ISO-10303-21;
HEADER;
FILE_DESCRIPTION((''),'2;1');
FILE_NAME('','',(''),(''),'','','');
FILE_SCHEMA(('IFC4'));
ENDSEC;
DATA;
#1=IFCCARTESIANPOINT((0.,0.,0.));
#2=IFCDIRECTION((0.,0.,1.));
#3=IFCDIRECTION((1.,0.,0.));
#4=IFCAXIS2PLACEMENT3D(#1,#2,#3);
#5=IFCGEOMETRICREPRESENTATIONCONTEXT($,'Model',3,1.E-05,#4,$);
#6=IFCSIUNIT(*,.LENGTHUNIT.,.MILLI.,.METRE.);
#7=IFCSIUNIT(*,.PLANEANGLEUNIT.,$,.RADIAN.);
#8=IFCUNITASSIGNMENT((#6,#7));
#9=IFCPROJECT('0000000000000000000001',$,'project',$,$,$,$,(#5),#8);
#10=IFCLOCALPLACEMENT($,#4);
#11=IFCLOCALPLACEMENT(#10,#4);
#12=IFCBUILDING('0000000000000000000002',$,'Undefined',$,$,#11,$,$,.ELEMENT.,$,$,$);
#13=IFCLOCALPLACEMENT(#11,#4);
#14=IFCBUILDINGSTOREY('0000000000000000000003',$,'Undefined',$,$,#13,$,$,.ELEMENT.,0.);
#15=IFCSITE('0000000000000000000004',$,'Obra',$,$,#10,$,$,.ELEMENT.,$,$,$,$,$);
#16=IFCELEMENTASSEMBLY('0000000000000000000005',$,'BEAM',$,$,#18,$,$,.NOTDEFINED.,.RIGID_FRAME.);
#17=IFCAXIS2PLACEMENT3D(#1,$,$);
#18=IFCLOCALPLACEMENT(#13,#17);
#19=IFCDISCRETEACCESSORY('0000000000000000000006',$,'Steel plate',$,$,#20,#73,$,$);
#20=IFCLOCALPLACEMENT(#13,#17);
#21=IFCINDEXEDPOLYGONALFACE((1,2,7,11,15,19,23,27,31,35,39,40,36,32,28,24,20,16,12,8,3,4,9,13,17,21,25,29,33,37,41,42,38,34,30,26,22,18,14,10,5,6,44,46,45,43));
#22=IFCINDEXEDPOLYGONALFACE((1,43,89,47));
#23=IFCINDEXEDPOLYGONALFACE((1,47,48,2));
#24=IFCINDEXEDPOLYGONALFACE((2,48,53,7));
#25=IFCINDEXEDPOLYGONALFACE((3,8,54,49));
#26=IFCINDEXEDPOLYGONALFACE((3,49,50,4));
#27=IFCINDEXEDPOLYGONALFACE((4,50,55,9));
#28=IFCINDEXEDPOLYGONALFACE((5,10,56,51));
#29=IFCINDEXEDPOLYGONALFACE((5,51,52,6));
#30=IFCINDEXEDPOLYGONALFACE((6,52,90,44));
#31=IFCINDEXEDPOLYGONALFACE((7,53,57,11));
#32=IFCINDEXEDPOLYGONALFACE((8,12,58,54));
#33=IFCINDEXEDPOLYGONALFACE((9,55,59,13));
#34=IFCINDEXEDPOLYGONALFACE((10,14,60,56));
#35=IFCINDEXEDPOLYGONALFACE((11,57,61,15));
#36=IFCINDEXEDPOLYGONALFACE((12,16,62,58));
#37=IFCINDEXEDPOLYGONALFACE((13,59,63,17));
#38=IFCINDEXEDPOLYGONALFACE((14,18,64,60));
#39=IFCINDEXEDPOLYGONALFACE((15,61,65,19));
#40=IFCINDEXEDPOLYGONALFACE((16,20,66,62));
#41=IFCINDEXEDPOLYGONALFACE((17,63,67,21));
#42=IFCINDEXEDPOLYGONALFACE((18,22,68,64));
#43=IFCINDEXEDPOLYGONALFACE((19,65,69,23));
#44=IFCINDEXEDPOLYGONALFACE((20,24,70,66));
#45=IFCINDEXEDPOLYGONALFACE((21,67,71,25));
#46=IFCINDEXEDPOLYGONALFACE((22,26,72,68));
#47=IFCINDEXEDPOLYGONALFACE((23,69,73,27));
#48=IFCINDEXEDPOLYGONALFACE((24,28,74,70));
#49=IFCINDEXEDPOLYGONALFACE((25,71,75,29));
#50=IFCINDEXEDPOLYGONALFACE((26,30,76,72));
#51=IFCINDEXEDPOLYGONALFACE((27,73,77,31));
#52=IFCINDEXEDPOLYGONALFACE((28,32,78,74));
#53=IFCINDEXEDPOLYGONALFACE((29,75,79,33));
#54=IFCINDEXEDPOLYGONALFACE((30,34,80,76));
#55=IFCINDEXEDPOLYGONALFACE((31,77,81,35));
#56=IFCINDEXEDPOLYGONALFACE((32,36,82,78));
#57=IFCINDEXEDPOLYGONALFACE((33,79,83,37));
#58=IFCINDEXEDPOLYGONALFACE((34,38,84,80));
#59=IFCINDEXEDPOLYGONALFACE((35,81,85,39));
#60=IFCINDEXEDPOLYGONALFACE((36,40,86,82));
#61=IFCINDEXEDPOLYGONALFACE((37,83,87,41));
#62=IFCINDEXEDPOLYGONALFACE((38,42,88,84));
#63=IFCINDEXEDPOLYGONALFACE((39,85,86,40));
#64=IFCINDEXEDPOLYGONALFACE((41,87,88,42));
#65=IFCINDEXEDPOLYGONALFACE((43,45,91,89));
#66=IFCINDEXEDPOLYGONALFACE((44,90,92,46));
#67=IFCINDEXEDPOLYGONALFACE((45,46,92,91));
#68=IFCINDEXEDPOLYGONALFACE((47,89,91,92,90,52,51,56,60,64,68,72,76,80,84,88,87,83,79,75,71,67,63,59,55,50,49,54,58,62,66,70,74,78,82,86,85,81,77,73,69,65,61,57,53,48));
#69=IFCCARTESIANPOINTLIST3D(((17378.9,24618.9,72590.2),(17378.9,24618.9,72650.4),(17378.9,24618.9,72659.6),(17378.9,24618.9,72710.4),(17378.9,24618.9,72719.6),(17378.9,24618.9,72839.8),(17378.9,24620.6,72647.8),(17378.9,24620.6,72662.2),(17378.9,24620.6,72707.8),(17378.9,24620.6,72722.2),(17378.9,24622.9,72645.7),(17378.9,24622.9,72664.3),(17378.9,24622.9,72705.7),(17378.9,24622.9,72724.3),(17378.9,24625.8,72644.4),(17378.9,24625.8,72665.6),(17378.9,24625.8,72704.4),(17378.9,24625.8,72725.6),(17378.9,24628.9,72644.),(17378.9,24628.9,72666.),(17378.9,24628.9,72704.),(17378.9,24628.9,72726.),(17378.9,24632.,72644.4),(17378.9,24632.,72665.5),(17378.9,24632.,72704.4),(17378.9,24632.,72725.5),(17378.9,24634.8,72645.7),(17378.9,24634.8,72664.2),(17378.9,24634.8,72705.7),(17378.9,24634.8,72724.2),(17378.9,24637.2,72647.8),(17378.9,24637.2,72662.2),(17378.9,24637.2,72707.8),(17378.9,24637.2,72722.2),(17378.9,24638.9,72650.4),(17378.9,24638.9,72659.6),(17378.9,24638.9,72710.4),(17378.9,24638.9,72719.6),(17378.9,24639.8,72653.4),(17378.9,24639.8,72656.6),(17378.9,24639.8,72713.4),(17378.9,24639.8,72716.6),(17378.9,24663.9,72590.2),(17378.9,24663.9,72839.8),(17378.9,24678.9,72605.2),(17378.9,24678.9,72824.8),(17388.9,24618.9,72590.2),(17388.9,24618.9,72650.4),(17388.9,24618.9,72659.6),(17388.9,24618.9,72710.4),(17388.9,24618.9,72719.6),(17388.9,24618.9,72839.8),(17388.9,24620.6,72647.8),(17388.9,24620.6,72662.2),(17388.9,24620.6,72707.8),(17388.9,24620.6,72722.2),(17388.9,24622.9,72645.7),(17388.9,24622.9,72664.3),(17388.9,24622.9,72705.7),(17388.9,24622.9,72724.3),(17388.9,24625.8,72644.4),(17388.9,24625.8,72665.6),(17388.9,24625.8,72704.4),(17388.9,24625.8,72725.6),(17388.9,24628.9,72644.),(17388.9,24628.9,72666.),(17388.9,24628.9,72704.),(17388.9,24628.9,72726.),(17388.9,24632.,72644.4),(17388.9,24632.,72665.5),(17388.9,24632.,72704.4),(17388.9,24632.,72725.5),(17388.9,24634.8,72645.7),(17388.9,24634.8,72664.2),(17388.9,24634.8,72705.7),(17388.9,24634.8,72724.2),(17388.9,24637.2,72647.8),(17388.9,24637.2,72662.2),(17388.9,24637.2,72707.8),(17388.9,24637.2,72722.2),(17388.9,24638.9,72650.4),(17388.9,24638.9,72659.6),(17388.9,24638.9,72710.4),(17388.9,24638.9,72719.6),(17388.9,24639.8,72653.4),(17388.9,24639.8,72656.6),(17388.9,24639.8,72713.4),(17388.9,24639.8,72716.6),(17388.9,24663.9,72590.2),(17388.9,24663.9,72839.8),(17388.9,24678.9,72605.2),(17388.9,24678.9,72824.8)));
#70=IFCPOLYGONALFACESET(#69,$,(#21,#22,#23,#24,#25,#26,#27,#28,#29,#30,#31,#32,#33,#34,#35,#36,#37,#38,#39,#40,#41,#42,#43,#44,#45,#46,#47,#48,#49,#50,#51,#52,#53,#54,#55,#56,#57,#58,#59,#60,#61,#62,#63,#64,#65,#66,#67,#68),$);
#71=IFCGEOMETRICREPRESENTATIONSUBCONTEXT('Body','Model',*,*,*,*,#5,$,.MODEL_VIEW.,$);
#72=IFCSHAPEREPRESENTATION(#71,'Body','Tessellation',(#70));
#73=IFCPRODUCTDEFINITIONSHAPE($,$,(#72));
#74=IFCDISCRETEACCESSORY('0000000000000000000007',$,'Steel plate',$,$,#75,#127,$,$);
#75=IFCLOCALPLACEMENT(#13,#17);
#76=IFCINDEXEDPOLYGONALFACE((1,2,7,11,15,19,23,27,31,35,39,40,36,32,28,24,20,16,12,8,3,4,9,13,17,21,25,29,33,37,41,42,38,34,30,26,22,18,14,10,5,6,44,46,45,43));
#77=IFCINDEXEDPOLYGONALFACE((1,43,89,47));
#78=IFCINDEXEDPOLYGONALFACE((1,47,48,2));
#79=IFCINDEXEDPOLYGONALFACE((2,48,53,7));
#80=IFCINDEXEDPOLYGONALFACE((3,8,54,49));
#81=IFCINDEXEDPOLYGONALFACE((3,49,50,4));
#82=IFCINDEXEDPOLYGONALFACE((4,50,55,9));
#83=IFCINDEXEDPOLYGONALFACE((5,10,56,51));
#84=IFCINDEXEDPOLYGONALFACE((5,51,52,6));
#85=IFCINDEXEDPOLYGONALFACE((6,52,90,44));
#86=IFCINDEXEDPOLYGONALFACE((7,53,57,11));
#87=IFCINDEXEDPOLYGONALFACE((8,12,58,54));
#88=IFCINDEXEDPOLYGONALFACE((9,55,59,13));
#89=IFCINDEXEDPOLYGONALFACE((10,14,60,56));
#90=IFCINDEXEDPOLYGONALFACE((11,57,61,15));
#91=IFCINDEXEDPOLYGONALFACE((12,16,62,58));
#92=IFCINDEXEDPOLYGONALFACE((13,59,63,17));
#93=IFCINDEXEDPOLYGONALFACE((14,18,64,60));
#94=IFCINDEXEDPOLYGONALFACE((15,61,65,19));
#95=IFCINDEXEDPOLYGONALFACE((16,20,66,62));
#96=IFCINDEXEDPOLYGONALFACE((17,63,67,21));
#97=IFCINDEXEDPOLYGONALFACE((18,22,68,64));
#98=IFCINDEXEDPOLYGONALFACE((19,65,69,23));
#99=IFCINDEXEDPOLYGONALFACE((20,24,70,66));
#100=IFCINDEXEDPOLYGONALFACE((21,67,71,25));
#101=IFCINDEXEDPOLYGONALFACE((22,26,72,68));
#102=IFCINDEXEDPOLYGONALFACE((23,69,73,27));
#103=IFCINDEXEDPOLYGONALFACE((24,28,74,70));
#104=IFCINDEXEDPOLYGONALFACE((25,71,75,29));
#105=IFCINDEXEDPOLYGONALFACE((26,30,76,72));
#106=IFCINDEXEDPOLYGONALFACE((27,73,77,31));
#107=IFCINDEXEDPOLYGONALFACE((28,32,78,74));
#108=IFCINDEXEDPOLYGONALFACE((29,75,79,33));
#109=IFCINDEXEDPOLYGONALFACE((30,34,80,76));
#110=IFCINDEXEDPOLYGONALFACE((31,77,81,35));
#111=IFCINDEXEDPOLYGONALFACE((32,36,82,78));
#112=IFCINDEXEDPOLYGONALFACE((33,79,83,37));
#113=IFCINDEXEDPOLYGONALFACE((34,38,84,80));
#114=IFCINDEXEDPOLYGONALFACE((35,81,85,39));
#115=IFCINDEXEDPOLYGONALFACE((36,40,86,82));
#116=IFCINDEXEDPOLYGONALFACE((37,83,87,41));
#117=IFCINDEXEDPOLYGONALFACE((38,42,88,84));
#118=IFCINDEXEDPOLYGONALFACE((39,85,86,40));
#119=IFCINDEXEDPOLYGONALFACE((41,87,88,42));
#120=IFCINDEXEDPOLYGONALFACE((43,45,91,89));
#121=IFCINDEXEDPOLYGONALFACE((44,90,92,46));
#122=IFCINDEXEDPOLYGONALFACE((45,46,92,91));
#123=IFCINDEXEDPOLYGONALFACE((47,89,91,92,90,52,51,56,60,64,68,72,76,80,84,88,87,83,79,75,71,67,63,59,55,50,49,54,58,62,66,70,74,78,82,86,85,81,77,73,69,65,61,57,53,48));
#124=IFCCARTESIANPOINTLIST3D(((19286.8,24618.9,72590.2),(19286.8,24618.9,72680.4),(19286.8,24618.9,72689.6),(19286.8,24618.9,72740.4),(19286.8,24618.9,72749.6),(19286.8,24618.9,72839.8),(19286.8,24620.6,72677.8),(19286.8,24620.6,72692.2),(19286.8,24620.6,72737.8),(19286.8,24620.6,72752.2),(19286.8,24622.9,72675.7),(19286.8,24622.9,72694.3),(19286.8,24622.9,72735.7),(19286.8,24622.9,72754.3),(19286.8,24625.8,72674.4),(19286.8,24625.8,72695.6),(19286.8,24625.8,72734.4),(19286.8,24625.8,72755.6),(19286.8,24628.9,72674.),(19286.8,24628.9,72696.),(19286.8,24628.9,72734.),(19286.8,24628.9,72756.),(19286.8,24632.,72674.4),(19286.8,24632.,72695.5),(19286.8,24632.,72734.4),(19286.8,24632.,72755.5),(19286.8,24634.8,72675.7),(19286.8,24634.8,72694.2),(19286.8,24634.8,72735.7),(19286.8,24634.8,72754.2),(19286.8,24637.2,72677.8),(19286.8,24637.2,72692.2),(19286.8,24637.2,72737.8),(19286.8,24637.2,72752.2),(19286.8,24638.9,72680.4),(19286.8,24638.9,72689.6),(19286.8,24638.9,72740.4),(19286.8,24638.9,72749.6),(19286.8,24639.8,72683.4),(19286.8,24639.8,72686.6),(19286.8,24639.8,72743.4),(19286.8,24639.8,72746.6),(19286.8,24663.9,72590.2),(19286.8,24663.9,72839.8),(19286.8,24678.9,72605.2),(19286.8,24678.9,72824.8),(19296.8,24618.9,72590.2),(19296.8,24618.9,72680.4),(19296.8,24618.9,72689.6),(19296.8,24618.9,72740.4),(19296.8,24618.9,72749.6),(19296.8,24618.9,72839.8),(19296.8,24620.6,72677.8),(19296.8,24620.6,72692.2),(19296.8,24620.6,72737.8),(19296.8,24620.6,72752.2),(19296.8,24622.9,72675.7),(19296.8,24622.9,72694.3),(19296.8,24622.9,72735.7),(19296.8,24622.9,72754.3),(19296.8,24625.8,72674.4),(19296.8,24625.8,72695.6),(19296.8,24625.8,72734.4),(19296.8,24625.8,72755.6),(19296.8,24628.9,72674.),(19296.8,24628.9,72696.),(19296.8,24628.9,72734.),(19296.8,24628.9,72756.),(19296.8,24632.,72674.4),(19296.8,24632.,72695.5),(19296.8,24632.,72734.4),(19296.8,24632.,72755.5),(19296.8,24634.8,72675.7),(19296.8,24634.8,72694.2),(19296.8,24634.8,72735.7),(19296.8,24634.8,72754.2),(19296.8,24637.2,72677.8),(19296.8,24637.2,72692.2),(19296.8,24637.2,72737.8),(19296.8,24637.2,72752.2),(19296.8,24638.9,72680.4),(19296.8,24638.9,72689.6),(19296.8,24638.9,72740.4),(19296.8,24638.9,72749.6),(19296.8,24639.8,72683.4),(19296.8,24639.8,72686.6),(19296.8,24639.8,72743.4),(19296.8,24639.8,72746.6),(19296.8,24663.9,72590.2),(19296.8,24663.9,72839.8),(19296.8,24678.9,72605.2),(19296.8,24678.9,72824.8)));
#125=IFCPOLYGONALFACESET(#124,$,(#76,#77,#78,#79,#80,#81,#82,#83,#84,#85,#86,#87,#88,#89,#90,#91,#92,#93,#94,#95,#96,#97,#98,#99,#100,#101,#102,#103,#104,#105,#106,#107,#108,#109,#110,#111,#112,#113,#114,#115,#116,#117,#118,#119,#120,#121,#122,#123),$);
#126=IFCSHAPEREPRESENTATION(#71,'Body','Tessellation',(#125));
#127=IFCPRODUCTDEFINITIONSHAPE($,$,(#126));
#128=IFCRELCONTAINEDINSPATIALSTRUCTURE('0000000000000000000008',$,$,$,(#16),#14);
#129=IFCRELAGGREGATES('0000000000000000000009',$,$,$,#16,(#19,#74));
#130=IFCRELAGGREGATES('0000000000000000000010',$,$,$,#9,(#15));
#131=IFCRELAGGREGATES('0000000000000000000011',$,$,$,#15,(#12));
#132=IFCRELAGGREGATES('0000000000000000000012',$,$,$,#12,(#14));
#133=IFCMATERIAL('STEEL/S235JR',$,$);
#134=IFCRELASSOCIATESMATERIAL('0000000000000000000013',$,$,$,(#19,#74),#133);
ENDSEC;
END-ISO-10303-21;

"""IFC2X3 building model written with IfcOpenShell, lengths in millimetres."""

from ifc_helpers import new_model, si_unit, frame, origin_with_axes, origin_2d_with_axis, place, context, subcontext, project, spatial, polyline, circle, outline, extrude, source, transform, mapped, material, element, aggregate, save


model = new_model("IFC2X3")

# Units and contexts
model_context = context("Model", 3, precision=1e-05, world=origin_with_axes())
body_context = subcontext(model_context, "Body", "Model", "MODEL_VIEW")
ifc_project = project(units=[si_unit("LENGTHUNIT", "METRE", prefix="MILLI"), si_unit("PLANEANGLEUNIT", "RADIAN")], contexts=[model_context])

# Site, building, storey
site_placement = place(None, origin_with_axes())
site = spatial("IfcSite", under=ifc_project, at=site_placement, Name="Obra", CompositionType="ELEMENT")
building_placement = place(site_placement, origin_with_axes())
building = spatial("IfcBuilding", under=site, at=building_placement, Name="Undefined", CompositionType="ELEMENT")
storey_placement = place(building_placement, origin_with_axes())
storey = spatial("IfcBuildingStorey", under=building, at=storey_placement, Name="Undefined", CompositionType="ELEMENT", Elevation=0.0)

# Shared definitions
ifc_material_1 = material(Name="STEEL/S235JR")

# Element assembly
assembly_1_placement = place(storey_placement, origin_with_axes())
assembly_1 = element("IfcElementAssembly", 1, at=assembly_1_placement, inside=storey, Name="BEAM", AssemblyPlace="NOTDEFINED", PredefinedType="RIGID_FRAME")

# Discrete accessories, openings
discrete_accessory_1_placement = place(assembly_1_placement, frame((17383.9, 24618.9, 72590.2), z_axis=(1.0, 0.000002, 0.0), x_axis=(-0.000002, 1.0, 0.0)))
discrete_accessory_1 = element("IfcDiscreteAccessory", 2, at=discrete_accessory_1_placement, material=ifc_material_1, Name="Steel plate", context=body_context, shape_type="SweptSolid", body=[
    extrude(outline(polyline([(0.0, 0.0), (45.0, 0.0), (60.0, 15.0), (60.0, 234.6), (45.0, 249.6), (0.0, 249.6), (0.0, 0.0)])), frame((0.0, 0.0, -5.0), z_axis=(0.0, 0.0, 1.0), x_axis=(1.0, 0.0, 0.0)), (0.0, 0.0, 1.0), 10.0),
])
shared_shape_1 = source(origin_with_axes(), body_context, "Body", "SweptSolid", [
    extrude(circle(Radius=11.0, at=origin_2d_with_axis()), frame((0.0, -13.9, 0.0), z_axis=(0.0, 1.0, 0.0), x_axis=(1.0, 0.0, 0.0)), (0.0, 0.0, 1.0), 10.2),
])
opening_1_placement = place(assembly_1_placement, frame((17392.7, 24668.9, 72850.0), z_axis=(0.000002, -1.0, 0.0), x_axis=(0.0, 0.0, -1.0)))
element("IfcOpeningElement", 3, at=opening_1_placement, cuts=discrete_accessory_1, ObjectType="Opening", context=body_context, shape_type="MappedRepresentation", body=[
    mapped(shared_shape_1, transform((135.0, 0.0, 40.0))),
    mapped(shared_shape_1, transform((195.0, 0.0, 40.0))),
])
discrete_accessory_2_placement = place(assembly_1_placement, frame((19291.8, 24618.9, 72590.2), z_axis=(1.0, 0.000002, 0.0), x_axis=(-0.000002, 1.0, 0.0)))
discrete_accessory_2 = element("IfcDiscreteAccessory", 4, at=discrete_accessory_2_placement, material=ifc_material_1, Name="Steel plate", context=body_context, shape_type="SweptSolid", body=[
    extrude(outline(polyline([(0.0, 0.0), (45.0, 0.0), (60.0, 15.0), (60.0, 234.6), (45.0, 249.6), (0.0, 249.6), (0.0, 0.0)])), frame((0.0, 0.0, -5.0), z_axis=(0.0, 0.0, 1.0), x_axis=(1.0, 0.0, 0.0)), (0.0, 0.0, 1.0), 10.0),
])
shared_shape_2 = source(origin_with_axes(), body_context, "Body", "SweptSolid", [
    extrude(circle(Radius=11.0, at=origin_2d_with_axis()), frame((0.0, -13.4, 0.0), z_axis=(0.0, 1.0, 0.0), x_axis=(1.0, 0.0, 0.0)), (0.0, 0.0, 1.0), 10.2),
])
opening_2_placement = place(assembly_1_placement, frame((19300.1, 24668.9, 72850.0), z_axis=(0.000002, -1.0, 0.0), x_axis=(0.0, 0.0, -1.0)))
element("IfcOpeningElement", 5, at=opening_2_placement, cuts=discrete_accessory_2, ObjectType="Opening", context=body_context, shape_type="MappedRepresentation", body=[
    mapped(shared_shape_2, transform((105.0, 0.0, 40.0))),
    mapped(shared_shape_2, transform((165.0, 0.0, 40.0))),
])
aggregate(assembly_1, [discrete_accessory_1, discrete_accessory_2])

save(model, "model.ifc")
